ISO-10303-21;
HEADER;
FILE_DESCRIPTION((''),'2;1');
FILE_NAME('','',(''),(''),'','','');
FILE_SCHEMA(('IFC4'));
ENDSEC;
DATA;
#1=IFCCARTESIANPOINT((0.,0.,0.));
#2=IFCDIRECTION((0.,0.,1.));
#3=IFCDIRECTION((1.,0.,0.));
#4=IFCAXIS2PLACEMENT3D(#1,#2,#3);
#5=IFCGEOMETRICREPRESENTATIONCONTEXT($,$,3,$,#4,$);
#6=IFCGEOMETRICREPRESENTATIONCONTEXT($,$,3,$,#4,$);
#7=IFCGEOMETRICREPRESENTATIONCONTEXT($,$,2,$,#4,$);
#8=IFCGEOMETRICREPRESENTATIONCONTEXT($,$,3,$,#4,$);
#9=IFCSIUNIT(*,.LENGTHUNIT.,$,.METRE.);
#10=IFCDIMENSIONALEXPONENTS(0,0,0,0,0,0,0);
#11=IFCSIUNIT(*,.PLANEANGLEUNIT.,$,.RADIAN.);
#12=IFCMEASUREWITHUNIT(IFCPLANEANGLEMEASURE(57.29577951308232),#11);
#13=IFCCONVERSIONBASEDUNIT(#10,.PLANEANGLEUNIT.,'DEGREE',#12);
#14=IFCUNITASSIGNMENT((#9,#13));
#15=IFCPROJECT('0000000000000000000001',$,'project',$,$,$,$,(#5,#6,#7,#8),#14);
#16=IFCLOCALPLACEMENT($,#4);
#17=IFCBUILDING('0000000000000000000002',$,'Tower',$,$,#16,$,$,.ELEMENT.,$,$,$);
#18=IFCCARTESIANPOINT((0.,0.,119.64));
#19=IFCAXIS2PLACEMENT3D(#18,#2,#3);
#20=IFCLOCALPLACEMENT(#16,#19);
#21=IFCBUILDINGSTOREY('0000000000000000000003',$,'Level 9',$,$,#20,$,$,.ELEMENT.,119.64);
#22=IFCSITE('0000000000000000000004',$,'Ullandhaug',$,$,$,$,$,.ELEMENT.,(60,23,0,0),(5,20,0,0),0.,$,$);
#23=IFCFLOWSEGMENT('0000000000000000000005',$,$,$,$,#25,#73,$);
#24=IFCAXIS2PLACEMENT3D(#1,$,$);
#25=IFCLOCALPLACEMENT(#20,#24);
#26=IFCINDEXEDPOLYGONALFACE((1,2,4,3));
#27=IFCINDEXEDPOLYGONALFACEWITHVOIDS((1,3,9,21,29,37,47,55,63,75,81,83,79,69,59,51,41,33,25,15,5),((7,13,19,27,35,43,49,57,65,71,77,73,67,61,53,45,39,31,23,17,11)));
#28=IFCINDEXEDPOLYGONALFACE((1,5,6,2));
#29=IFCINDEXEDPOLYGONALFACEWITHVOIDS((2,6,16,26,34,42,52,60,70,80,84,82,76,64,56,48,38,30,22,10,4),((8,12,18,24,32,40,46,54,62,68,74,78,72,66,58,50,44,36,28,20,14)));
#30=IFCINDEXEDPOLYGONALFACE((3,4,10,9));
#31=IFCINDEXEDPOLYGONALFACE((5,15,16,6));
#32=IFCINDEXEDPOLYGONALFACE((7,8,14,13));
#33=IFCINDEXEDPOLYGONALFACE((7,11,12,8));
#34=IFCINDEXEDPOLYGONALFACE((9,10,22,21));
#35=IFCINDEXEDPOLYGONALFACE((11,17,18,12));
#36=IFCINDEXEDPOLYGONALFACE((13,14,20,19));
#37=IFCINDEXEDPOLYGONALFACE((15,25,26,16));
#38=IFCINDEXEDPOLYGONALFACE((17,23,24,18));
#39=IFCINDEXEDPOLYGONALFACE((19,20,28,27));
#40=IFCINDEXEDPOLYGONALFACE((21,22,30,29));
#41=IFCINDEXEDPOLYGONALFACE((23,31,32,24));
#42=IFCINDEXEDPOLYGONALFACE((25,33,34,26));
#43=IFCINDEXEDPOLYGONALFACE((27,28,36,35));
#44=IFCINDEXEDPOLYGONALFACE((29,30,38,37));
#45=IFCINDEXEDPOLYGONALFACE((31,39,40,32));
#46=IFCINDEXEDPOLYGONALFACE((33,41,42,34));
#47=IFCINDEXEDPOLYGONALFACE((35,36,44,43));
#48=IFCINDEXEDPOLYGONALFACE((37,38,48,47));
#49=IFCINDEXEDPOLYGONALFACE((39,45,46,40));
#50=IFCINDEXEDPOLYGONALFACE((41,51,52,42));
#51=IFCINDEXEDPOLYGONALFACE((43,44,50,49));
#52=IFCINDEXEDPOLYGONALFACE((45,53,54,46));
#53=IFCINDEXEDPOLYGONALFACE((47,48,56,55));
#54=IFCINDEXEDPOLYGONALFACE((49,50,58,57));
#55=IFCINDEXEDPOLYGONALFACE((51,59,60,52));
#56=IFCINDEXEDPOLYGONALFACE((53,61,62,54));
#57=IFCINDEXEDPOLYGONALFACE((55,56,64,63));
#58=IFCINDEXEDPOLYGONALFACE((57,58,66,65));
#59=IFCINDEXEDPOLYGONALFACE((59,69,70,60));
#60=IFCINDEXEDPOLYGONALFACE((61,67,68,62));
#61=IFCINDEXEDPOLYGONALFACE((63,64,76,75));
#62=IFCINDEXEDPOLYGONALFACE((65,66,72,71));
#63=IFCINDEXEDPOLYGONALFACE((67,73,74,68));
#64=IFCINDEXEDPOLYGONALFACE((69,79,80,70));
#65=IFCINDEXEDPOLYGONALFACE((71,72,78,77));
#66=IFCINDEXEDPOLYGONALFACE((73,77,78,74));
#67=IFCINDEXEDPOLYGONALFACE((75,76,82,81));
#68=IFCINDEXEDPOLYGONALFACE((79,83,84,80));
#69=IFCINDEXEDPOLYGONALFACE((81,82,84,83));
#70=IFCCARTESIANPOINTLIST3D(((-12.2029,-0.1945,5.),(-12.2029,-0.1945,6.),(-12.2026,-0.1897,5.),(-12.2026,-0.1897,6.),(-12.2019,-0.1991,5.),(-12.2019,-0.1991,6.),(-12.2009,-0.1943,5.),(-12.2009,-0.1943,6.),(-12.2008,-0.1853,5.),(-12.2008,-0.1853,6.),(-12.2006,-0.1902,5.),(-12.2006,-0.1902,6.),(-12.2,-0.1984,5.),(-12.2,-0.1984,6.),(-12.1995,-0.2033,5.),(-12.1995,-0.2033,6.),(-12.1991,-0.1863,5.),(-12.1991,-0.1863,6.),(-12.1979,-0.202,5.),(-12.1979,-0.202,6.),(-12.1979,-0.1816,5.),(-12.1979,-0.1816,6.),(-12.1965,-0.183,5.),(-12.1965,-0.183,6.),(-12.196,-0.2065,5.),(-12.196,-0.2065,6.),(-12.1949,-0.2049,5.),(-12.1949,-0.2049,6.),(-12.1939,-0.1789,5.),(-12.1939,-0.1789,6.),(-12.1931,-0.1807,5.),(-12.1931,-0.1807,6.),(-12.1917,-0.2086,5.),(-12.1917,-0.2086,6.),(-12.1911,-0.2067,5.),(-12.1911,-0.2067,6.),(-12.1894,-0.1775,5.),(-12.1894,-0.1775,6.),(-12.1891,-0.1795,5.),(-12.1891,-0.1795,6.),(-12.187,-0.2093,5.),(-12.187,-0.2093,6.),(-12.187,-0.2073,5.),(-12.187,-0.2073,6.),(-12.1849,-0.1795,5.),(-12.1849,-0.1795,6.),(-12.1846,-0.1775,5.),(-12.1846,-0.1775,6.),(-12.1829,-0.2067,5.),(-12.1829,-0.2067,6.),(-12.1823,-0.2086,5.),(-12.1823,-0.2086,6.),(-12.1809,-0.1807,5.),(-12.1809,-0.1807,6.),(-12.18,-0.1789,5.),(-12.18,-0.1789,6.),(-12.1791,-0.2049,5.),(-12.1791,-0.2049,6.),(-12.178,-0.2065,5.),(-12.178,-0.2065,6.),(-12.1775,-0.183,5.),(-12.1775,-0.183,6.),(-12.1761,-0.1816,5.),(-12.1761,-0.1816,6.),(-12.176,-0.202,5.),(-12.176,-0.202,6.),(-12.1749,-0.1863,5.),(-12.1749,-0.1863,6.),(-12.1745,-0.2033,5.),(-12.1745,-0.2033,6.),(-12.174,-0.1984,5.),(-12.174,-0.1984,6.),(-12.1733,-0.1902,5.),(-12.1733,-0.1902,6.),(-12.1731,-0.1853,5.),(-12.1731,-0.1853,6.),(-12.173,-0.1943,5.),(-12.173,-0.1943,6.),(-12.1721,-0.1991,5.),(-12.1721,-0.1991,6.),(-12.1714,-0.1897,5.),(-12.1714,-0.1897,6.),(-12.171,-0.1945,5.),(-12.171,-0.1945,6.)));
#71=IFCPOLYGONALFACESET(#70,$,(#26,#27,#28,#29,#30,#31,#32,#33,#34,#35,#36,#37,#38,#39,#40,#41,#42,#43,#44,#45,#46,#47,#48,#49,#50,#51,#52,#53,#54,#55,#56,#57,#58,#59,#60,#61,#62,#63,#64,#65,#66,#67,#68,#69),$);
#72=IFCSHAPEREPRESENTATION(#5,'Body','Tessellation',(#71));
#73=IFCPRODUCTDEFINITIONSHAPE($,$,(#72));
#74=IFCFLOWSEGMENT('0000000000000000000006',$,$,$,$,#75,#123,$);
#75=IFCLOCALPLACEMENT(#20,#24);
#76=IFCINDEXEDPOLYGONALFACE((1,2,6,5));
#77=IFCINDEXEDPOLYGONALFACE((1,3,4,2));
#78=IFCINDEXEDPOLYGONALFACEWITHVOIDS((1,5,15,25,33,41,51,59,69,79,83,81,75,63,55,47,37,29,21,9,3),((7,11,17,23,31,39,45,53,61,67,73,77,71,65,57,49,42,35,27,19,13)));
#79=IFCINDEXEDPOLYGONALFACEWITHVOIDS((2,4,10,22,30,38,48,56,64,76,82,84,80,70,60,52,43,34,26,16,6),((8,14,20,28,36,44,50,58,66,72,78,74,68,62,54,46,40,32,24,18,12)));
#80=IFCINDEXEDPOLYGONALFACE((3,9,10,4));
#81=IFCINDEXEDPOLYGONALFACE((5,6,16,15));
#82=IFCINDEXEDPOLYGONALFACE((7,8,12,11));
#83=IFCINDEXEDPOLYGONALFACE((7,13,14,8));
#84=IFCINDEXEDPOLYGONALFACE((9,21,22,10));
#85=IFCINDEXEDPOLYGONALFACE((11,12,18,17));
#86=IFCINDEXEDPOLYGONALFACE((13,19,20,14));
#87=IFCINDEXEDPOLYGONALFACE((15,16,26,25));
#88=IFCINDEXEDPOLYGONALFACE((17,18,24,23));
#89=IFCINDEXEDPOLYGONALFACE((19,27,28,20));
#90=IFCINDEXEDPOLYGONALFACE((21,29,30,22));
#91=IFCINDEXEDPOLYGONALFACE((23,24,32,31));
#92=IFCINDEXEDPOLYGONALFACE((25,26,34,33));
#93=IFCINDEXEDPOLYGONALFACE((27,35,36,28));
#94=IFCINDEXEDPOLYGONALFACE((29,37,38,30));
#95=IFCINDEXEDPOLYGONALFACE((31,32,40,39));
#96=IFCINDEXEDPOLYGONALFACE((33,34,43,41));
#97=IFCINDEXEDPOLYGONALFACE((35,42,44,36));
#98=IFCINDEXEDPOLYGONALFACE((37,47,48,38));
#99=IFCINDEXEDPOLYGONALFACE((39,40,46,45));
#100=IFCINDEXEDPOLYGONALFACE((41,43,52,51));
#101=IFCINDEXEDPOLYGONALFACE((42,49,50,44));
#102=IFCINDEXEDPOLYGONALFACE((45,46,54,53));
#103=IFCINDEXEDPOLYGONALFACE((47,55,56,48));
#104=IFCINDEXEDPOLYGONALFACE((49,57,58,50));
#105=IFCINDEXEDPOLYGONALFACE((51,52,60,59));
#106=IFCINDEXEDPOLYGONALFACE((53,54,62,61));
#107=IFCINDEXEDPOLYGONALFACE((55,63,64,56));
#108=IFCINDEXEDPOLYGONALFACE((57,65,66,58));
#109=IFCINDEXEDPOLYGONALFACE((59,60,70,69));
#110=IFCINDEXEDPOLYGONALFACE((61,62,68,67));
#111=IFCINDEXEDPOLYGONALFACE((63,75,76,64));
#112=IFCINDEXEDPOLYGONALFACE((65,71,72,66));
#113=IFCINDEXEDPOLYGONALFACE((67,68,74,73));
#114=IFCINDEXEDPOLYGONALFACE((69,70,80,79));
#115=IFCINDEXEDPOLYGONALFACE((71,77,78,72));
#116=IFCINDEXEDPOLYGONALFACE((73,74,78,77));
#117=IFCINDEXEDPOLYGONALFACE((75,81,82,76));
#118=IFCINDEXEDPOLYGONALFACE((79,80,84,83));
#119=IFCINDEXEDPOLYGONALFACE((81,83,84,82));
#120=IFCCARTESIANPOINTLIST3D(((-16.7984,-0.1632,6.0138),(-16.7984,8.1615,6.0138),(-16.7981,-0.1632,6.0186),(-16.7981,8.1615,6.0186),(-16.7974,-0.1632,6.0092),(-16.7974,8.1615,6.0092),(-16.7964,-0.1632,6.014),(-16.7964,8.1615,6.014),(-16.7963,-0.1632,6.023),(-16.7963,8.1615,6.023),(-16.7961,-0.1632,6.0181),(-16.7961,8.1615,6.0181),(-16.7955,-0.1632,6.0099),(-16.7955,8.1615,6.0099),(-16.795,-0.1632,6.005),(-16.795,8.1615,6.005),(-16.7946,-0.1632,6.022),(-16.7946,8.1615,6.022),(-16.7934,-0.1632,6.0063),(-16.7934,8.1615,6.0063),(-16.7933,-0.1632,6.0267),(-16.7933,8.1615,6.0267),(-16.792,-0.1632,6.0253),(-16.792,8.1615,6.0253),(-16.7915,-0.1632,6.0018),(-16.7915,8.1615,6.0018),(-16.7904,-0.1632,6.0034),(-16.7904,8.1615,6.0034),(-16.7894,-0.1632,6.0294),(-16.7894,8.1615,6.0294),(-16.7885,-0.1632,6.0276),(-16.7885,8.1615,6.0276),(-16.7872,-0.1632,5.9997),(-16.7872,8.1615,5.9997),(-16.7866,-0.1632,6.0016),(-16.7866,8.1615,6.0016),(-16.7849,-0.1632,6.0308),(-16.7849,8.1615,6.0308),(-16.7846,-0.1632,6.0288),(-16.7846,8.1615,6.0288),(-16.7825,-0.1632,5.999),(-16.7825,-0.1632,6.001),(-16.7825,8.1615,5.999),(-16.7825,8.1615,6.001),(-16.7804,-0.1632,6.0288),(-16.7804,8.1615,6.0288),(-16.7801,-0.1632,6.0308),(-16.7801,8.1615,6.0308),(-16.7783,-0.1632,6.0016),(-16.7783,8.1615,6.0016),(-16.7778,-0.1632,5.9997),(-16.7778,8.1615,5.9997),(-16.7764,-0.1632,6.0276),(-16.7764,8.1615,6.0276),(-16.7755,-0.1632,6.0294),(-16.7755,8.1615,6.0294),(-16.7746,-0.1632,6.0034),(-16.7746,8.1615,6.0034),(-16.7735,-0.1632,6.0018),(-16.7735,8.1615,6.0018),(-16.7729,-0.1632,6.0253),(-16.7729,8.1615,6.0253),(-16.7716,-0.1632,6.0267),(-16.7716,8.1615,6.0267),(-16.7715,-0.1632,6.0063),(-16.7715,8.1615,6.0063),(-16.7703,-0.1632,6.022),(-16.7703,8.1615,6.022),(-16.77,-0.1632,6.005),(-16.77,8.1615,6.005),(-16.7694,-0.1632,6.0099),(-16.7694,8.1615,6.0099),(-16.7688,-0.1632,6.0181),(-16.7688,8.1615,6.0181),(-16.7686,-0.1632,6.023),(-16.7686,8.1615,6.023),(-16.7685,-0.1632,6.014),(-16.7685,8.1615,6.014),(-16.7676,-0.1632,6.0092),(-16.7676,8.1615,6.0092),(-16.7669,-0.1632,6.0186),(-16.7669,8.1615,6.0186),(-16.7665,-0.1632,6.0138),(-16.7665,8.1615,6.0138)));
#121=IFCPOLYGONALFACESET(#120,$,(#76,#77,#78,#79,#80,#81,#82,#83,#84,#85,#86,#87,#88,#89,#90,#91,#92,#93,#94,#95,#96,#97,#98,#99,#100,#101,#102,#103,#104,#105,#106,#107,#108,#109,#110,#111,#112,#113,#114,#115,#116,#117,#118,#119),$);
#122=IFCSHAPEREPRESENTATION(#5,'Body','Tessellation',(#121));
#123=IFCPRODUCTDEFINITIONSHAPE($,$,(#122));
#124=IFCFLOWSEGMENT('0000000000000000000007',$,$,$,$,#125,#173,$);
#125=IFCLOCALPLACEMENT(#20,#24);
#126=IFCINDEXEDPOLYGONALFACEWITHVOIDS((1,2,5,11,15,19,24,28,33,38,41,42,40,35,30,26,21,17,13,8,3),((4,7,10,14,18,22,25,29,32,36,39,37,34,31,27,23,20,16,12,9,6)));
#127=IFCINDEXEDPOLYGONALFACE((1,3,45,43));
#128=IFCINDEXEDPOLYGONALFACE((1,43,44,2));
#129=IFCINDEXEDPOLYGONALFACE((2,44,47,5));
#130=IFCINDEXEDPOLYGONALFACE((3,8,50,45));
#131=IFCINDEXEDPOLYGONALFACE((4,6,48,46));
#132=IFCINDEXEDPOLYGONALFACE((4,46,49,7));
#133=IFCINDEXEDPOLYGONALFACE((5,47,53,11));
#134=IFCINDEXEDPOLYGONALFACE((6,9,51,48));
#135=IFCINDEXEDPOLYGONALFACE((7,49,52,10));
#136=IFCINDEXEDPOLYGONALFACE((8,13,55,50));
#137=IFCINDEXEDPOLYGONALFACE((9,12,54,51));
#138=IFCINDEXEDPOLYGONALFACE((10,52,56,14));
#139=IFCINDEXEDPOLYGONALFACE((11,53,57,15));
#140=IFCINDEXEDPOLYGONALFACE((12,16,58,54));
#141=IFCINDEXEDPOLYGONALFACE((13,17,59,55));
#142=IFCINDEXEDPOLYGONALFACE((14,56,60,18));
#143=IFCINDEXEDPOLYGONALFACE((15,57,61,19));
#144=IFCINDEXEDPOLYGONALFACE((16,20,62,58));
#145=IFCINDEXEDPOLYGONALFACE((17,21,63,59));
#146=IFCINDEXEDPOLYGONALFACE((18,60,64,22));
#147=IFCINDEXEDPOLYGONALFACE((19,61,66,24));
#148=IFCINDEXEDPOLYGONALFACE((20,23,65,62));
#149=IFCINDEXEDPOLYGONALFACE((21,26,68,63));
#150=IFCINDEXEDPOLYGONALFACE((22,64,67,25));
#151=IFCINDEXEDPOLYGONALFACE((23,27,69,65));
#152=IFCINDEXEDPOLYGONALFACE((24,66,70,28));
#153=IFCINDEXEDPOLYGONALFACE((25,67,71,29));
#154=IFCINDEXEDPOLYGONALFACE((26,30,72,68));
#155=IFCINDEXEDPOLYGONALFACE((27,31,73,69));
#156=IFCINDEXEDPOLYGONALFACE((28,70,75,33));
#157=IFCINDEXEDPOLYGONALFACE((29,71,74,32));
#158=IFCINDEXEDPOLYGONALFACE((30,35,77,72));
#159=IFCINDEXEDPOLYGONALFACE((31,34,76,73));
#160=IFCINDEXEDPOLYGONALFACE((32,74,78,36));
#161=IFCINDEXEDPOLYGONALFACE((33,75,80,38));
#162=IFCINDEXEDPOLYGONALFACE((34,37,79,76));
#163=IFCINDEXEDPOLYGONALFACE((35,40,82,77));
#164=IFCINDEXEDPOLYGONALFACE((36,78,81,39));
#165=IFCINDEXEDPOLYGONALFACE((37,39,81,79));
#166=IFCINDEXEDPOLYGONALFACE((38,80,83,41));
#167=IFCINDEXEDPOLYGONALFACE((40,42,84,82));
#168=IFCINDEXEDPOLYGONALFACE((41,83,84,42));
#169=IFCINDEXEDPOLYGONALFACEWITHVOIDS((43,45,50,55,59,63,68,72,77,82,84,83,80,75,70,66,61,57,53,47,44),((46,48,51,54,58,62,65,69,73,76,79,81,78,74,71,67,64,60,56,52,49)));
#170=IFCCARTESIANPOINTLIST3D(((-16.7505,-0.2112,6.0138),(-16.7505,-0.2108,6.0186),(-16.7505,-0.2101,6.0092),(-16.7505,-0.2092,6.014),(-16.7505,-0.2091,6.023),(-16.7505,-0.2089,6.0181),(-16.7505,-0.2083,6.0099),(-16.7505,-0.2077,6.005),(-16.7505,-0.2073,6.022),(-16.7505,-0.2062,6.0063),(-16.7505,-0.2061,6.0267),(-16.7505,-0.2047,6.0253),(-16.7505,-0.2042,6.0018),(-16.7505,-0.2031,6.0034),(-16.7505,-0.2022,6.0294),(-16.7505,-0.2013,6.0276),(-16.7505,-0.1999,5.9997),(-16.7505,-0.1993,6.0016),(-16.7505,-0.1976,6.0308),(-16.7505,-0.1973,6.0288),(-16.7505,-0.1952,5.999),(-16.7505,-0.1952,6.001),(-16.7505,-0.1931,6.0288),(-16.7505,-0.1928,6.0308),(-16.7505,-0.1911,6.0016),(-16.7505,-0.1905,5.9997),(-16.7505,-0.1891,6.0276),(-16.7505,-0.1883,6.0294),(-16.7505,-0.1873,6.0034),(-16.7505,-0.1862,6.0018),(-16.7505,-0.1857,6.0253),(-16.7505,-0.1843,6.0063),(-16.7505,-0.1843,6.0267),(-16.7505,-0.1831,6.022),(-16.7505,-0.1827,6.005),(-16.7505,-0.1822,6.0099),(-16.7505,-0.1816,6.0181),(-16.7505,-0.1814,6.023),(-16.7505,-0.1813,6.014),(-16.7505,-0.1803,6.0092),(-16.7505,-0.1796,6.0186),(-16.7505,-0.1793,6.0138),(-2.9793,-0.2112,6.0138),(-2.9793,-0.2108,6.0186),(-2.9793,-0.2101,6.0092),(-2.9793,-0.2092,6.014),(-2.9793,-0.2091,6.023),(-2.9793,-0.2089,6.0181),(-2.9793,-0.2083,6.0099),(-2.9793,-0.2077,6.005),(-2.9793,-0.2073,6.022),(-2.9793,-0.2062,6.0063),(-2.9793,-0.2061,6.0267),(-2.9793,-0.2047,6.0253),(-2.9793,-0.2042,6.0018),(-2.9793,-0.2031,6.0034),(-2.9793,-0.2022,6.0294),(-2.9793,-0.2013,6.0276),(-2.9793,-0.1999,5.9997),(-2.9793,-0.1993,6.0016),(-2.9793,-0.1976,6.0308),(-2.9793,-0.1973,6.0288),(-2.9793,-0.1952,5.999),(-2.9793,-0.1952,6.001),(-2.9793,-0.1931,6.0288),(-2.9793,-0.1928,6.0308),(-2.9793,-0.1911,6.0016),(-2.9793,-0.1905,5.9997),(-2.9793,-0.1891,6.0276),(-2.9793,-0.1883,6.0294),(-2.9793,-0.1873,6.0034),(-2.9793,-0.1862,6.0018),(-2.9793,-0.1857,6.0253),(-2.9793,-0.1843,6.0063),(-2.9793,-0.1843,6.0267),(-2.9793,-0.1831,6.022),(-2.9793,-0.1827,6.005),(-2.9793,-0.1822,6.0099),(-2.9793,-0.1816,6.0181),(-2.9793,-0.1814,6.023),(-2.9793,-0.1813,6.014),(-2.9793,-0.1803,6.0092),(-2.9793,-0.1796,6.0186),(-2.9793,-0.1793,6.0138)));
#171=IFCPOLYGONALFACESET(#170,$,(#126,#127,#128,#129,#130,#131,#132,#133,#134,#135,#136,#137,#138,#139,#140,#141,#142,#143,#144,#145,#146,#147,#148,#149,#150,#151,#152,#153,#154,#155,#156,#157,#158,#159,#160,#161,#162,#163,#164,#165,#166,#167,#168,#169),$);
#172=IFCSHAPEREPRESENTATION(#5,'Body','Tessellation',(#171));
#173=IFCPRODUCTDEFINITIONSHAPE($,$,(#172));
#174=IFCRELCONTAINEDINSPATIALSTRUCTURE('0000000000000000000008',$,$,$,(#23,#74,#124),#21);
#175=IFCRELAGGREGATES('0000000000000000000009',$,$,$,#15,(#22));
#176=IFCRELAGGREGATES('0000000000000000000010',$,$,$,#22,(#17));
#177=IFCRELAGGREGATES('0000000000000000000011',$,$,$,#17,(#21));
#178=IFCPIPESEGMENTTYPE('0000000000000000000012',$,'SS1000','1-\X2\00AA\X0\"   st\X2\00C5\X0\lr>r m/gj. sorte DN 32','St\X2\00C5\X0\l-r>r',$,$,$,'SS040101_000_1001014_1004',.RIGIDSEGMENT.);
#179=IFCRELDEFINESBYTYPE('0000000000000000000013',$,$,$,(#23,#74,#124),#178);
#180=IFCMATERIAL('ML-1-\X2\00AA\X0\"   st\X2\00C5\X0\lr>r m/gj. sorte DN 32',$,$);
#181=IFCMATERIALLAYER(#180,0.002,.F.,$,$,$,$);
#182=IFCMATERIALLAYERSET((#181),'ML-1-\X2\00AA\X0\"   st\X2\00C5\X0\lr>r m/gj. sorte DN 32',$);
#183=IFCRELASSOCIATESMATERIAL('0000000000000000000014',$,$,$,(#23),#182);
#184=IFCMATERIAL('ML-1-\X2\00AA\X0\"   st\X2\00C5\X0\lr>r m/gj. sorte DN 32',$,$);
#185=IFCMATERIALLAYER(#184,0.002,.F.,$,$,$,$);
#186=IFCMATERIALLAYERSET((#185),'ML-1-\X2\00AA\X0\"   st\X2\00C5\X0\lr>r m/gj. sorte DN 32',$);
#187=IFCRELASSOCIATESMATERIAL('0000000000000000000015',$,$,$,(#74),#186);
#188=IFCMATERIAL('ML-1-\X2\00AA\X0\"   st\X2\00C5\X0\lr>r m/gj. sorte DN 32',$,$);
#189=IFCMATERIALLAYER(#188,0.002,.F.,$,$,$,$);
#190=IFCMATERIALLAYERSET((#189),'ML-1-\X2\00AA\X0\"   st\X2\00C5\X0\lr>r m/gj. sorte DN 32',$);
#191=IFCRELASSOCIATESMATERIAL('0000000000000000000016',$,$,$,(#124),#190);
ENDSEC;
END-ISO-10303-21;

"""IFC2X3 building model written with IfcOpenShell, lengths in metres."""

from ifc_helpers import new_model, entity, si_unit, converted_unit, frame, origin_with_axes, origin_2d_with_axis, place, context, project, spatial, hollow_circle, extrude, material, layer, layer_set, layer_usage, type_object, element, save


model = new_model("IFC2X3")

# Units and contexts
context_of_model_1 = context(None, 3, world=origin_with_axes())
context_of_model_2 = context(None, 3, world=origin_with_axes())
context_of_model_3 = context(None, 2, world=origin_with_axes())
context_of_model_4 = context(None, 3, world=origin_with_axes())
ifc_project = project(units=[si_unit("LENGTHUNIT", "METRE"), converted_unit("PLANEANGLEUNIT", "DEGREE", entity("IfcPlaneAngleMeasure", 57.29577951308232), si_unit("PLANEANGLEUNIT", "RADIAN"), dimensions=[0, 0, 0, 0, 0, 0, 0])], contexts=[context_of_model_1, context_of_model_2, context_of_model_3, context_of_model_4])

# Site, building, storey
site = spatial("IfcSite", under=ifc_project, Name="Ullandhaug", CompositionType="ELEMENT", RefLatitude=(60, 23, 0, 0), RefLongitude=(5, 20, 0, 0), RefElevation=0.0)
building_placement = place(None, origin_with_axes())
building = spatial("IfcBuilding", under=site, at=building_placement, Name="Tower", CompositionType="ELEMENT")
storey_placement = place(building_placement, frame((0.0, 0.0, 119.64), z_axis=(0.0, 0.0, 1.0), x_axis=(1.0, 0.0, 0.0)))
storey = spatial("IfcBuildingStorey", under=building, at=storey_placement, Name="Level 9", CompositionType="ELEMENT", Elevation=119.64)

# Flow segments
pipe_segment_type_1 = type_object("IfcPipeSegmentType", Name="SS1000", Description="1-ª\"   stÅlr>r m/gj. sorte DN 32", ApplicableOccurrence="StÅl-r>r", ElementType="SS040101_000_1001014_1004", PredefinedType="RIGIDSEGMENT")
ifc_material_1 = material(Name="ML-1-ª\"   stÅlr>r m/gj. sorte DN 32")
ifc_layer_1 = layer(ifc_material_1, 0.002, ventilated=False)
ifc_layer_set_1 = layer_set([ifc_layer_1], Name="ML-1-ª\"   stÅlr>r m/gj. sorte DN 32")
ifc_layer_usage_1 = layer_usage(ifc_layer_set_1, "AXIS2", "POSITIVE", 0.0)
flow_segment_1_placement = place(storey_placement, frame((-12.187, -0.1933, 5.0), z_axis=(0.0, 0.0, 1.0), x_axis=(0.0, -1.0, 0.0)))
element("IfcFlowSegment", 1, at=flow_segment_1_placement, inside=storey, type_object=pipe_segment_type_1, material=ifc_layer_usage_1, context=context_of_model_1, shape_type="SweptSolid", body=[
    extrude(hollow_circle(Radius=0.016, WallThickness=0.002, at=origin_2d_with_axis()), origin_with_axes(), (0.0, 0.0, 1.0), 1.0),
])
ifc_material_2 = material(Name="ML-1-ª\"   stÅlr>r m/gj. sorte DN 32")
ifc_layer_2 = layer(ifc_material_2, 0.002, ventilated=False)
ifc_layer_set_2 = layer_set([ifc_layer_2], Name="ML-1-ª\"   stÅlr>r m/gj. sorte DN 32")
ifc_layer_usage_2 = layer_usage(ifc_layer_set_2, "AXIS2", "POSITIVE", 0.0)
flow_segment_2_placement = place(storey_placement, frame((-16.7825, 8.1615, 6.015), z_axis=(0.0, -1.0, 0.0), x_axis=(0.0, 0.0, -1.0)))
element("IfcFlowSegment", 2, at=flow_segment_2_placement, inside=storey, type_object=pipe_segment_type_1, material=ifc_layer_usage_2, context=context_of_model_1, shape_type="SweptSolid", body=[
    extrude(hollow_circle(Radius=0.016, WallThickness=0.002, at=origin_2d_with_axis()), origin_with_axes(), (0.0, 0.0, 1.0), 8.3247),
])
ifc_material_3 = material(Name="ML-1-ª\"   stÅlr>r m/gj. sorte DN 32")
ifc_layer_3 = layer(ifc_material_3, 0.002, ventilated=False)
ifc_layer_set_3 = layer_set([ifc_layer_3], Name="ML-1-ª\"   stÅlr>r m/gj. sorte DN 32")
ifc_layer_usage_3 = layer_usage(ifc_layer_set_3, "AXIS2", "POSITIVE", 0.0)
flow_segment_3_placement = place(storey_placement, frame((-16.7505, -0.1952, 6.015), z_axis=(1.0, 0.0, 0.0), x_axis=(0.0, 0.0, -1.0)))
element("IfcFlowSegment", 3, at=flow_segment_3_placement, inside=storey, type_object=pipe_segment_type_1, material=ifc_layer_usage_3, context=context_of_model_1, shape_type="SweptSolid", body=[
    extrude(hollow_circle(Radius=0.016, WallThickness=0.002, at=origin_2d_with_axis()), origin_with_axes(), (0.0, 0.0, 1.0), 13.7711),
])

save(model, "model.ifc")
